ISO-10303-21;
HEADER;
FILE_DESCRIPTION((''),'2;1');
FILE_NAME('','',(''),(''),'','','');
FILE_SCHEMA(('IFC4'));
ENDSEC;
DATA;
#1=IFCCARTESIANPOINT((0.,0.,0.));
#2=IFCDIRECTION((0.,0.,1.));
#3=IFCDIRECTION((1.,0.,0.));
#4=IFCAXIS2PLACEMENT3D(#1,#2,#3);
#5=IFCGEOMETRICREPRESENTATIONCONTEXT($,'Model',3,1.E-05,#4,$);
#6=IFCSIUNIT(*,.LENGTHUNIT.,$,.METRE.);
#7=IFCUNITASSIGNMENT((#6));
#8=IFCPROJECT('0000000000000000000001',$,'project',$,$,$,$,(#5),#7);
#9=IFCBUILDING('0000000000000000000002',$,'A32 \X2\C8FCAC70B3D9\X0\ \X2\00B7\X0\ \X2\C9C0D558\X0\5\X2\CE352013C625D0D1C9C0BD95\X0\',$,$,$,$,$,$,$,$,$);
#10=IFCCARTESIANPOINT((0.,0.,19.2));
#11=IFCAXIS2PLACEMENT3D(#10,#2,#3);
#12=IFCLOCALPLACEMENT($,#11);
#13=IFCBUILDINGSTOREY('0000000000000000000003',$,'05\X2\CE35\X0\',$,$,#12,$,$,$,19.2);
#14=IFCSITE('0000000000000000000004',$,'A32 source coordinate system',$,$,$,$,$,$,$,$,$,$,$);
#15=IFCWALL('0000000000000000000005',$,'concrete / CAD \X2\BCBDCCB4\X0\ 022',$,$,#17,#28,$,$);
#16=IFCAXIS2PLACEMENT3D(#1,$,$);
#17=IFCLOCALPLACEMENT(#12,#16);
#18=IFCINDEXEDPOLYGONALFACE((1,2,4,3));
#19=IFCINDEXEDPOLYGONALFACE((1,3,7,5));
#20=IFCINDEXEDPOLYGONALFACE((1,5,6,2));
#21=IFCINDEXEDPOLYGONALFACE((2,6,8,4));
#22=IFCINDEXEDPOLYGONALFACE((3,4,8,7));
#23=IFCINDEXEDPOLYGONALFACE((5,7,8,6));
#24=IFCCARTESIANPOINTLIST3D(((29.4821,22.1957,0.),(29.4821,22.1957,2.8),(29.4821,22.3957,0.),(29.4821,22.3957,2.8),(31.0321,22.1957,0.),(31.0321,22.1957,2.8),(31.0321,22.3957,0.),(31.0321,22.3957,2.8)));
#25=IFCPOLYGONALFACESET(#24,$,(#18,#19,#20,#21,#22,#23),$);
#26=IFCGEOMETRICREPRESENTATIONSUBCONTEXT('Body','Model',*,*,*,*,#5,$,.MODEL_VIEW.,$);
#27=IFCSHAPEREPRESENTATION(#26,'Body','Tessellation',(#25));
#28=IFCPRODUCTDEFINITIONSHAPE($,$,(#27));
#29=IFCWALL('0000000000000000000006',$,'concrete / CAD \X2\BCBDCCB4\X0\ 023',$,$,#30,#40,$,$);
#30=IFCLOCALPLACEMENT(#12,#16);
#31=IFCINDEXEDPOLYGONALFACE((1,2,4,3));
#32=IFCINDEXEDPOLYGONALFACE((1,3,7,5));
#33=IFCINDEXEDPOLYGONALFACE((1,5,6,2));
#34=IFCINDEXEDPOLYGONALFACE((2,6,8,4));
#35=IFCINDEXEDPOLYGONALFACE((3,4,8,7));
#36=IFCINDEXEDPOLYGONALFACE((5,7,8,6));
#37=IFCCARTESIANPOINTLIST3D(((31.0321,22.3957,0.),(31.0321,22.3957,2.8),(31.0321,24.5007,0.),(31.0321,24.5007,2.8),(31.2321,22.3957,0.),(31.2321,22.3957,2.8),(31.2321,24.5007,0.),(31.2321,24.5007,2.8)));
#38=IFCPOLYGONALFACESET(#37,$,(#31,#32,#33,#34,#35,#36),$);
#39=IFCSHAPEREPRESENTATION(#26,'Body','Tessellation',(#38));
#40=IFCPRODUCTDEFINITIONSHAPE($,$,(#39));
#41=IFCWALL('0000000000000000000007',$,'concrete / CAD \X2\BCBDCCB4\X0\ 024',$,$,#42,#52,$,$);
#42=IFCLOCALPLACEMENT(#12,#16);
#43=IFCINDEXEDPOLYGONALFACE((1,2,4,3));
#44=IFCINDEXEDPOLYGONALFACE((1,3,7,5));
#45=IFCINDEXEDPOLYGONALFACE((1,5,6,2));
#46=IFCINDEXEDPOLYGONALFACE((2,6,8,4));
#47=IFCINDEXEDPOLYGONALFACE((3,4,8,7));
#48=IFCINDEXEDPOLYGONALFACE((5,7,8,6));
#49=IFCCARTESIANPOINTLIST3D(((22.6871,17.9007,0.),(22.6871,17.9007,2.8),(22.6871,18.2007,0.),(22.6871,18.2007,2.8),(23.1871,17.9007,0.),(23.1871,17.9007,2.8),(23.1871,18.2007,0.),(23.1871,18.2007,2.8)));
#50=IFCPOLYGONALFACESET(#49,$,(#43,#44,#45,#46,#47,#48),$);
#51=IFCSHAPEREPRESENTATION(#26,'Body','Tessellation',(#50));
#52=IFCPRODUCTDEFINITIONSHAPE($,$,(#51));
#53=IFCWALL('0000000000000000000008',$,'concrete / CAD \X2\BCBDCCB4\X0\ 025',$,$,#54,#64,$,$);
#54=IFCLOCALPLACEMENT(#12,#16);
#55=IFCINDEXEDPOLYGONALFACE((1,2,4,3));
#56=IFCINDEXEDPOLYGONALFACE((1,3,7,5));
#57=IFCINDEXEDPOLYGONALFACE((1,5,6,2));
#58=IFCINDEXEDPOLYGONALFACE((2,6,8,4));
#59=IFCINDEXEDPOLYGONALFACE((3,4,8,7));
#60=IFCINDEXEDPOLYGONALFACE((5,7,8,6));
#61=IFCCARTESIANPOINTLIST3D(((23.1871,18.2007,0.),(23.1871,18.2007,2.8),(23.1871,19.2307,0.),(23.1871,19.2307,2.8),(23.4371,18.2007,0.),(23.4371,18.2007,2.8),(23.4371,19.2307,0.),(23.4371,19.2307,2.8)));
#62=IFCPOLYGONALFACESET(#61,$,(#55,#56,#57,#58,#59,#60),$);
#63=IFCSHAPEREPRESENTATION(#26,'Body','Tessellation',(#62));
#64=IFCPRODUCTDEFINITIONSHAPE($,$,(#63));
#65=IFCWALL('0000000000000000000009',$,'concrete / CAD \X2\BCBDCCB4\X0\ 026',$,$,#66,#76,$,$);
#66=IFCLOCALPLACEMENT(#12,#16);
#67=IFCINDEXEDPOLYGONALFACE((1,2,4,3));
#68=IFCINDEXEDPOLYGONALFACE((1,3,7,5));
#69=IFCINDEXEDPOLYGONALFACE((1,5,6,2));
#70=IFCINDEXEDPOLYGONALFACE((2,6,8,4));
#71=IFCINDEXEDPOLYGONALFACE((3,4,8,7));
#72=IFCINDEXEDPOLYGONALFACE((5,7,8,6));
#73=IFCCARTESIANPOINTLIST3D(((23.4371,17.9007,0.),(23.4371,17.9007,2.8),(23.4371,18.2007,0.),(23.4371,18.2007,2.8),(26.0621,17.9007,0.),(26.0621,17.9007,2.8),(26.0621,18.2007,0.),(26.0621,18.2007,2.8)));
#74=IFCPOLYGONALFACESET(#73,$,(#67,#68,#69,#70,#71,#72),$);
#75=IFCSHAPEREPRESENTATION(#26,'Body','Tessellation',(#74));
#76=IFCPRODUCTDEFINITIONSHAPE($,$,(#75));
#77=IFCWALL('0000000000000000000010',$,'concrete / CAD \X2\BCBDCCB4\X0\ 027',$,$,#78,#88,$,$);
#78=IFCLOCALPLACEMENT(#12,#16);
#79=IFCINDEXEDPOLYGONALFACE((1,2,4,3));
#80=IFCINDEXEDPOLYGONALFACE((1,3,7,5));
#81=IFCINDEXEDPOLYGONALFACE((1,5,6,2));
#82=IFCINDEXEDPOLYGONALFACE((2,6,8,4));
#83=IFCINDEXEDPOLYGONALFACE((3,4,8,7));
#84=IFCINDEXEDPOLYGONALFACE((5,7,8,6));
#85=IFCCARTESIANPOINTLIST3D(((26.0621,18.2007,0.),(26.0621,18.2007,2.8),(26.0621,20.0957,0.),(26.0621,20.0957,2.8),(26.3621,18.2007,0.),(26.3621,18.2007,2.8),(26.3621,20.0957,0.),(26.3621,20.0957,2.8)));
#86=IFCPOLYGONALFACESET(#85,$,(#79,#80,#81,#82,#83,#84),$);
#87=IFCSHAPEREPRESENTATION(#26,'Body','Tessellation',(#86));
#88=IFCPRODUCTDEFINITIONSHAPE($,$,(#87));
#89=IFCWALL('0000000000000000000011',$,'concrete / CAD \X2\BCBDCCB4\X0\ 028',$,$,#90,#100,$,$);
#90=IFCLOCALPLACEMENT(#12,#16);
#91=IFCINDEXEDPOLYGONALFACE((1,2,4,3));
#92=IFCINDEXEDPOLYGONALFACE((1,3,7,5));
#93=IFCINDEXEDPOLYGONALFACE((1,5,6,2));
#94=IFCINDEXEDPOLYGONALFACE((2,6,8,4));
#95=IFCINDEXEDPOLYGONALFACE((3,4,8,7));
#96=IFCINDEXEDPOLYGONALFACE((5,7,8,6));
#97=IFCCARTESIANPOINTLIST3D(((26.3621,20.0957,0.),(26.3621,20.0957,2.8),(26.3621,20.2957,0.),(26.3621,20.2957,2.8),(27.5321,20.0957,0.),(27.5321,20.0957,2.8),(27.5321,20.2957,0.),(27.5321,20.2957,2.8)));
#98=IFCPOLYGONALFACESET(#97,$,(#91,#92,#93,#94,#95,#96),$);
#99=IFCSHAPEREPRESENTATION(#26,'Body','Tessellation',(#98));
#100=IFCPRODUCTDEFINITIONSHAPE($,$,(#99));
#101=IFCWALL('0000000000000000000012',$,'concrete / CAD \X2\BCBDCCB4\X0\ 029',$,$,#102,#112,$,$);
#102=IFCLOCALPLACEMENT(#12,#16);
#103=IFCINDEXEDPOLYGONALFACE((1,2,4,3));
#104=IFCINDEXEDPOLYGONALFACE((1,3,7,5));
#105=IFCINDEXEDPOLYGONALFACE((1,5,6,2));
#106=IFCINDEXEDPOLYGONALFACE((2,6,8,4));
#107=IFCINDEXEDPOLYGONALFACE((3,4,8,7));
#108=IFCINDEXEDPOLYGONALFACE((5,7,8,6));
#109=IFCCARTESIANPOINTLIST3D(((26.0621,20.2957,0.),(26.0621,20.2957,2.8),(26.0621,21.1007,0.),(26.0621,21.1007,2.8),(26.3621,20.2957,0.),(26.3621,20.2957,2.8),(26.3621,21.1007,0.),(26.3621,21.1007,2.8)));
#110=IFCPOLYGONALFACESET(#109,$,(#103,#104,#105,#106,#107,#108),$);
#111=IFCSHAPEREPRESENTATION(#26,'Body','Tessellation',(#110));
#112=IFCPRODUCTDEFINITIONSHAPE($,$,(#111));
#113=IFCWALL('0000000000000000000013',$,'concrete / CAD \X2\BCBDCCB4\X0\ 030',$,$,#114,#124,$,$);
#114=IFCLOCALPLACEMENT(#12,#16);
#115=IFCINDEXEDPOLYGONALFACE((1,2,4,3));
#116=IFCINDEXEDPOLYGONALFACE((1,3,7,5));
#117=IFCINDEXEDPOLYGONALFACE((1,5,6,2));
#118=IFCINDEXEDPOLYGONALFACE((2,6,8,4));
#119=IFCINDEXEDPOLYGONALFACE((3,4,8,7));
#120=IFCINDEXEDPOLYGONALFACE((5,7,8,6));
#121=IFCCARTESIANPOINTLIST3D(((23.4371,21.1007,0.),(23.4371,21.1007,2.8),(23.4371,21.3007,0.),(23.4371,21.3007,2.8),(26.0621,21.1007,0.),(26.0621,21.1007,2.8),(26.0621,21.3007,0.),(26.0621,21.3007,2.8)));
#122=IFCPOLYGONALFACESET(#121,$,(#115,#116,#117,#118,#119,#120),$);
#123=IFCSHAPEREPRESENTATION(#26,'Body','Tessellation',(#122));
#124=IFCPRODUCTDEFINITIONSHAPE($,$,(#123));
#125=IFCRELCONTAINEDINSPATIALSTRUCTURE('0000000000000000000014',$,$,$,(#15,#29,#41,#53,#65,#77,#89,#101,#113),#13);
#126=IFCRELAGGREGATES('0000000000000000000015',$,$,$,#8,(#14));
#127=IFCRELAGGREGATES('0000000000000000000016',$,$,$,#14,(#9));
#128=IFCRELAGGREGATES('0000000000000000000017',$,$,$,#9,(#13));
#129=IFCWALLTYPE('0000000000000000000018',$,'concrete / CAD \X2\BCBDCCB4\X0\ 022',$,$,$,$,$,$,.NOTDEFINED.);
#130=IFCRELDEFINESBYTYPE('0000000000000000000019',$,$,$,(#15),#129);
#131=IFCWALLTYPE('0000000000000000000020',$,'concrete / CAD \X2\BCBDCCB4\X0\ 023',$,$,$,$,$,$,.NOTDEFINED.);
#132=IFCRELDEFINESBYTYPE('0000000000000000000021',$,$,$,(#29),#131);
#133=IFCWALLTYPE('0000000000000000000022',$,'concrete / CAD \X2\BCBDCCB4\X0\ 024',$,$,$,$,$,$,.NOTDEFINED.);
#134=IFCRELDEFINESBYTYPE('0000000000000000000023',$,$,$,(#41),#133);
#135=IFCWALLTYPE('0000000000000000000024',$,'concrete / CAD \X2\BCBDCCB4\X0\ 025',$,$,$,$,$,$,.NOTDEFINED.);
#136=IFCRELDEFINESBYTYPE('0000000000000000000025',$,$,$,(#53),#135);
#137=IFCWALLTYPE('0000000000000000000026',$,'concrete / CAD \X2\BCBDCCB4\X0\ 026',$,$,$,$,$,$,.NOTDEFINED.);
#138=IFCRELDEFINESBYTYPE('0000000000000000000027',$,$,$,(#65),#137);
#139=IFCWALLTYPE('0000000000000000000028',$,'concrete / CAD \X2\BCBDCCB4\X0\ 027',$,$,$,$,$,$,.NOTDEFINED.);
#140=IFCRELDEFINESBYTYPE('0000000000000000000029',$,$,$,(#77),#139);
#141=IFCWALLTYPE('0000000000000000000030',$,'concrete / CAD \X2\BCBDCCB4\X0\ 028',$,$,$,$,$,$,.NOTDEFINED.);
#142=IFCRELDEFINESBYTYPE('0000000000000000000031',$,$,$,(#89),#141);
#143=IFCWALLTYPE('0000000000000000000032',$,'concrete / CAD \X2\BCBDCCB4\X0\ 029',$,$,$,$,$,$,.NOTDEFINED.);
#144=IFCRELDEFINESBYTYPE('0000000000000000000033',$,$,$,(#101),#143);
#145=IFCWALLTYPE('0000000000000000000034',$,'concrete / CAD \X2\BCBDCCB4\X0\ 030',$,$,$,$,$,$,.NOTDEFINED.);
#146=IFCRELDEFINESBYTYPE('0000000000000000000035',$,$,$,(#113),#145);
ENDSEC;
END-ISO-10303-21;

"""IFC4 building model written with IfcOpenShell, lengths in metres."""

from ifc_helpers import new_model, si_unit, frame, origin, origin_with_axes, place, context, subcontext, project, spatial, polyline, outline, extrude, source, transform, mapped, type_object, type_shapes, element, save


model = new_model("IFC4")

# Units and contexts
model_context = context("Model", 3, precision=1e-05, world=origin_with_axes())
body_context = subcontext(model_context, "Body", "Model", "MODEL_VIEW")
ifc_project = project(units=[si_unit("LENGTHUNIT", "METRE")], contexts=[model_context])

# Site, building, storey
site = spatial("IfcSite", under=ifc_project, Name="A32 source coordinate system")
building = spatial("IfcBuilding", under=site, Name="A32 주거동 · 지하5층–옥탑지붕")
storey_placement = place(None, frame((0.0, 0.0, 19.2), z_axis=(0.0, 0.0, 1.0), x_axis=(1.0, 0.0, 0.0)))
storey = spatial("IfcBuildingStorey", under=building, at=storey_placement, Name="05층", Elevation=19.2)

# Walls
wall_type_1 = type_object("IfcWallType", Name="concrete / CAD 벽체 022", PredefinedType="NOTDEFINED")
shared_shape_1 = source(origin(), body_context, "Body", "SweptSolid", [
    extrude(outline(polyline([(31.0321, 22.1957), (29.4821, 22.1957), (29.4821, 22.3957), (31.0321, 22.3957), (31.0321, 22.1957)])), origin(), (0.0, 0.0, 1.0), 2.8),
])
type_shapes(wall_type_1, [shared_shape_1])
wall_1_placement = place(storey_placement, origin_with_axes())
element("IfcWall", 1, at=wall_1_placement, inside=storey, type_object=wall_type_1, Name="concrete / CAD 벽체 022", context=body_context, shape_type="MappedRepresentation", body=[
    mapped(shared_shape_1, transform((0.0, 0.0, 0.0), scale=1.0)),
])
wall_type_2 = type_object("IfcWallType", Name="concrete / CAD 벽체 023", PredefinedType="NOTDEFINED")
shared_shape_2 = source(origin(), body_context, "Body", "SweptSolid", [
    extrude(outline(polyline([(31.2321, 24.5007), (31.2321, 22.3957), (31.0321, 22.3957), (31.0321, 24.5007), (31.2321, 24.5007)])), origin(), (0.0, 0.0, 1.0), 2.8),
])
type_shapes(wall_type_2, [shared_shape_2])
wall_2_placement = place(storey_placement, origin_with_axes())
element("IfcWall", 2, at=wall_2_placement, inside=storey, type_object=wall_type_2, Name="concrete / CAD 벽체 023", context=body_context, shape_type="MappedRepresentation", body=[
    mapped(shared_shape_2, transform((0.0, 0.0, 0.0), scale=1.0)),
])
wall_type_3 = type_object("IfcWallType", Name="concrete / CAD 벽체 024", PredefinedType="NOTDEFINED")
shared_shape_3 = source(origin(), body_context, "Body", "SweptSolid", [
    extrude(outline(polyline([(23.1871, 17.9007), (22.6871, 17.9007), (22.6871, 18.2007), (23.1871, 18.2007), (23.1871, 17.9007)])), origin(), (0.0, 0.0, 1.0), 2.8),
])
type_shapes(wall_type_3, [shared_shape_3])
wall_3_placement = place(storey_placement, origin_with_axes())
element("IfcWall", 3, at=wall_3_placement, inside=storey, type_object=wall_type_3, Name="concrete / CAD 벽체 024", context=body_context, shape_type="MappedRepresentation", body=[
    mapped(shared_shape_3, transform((0.0, 0.0, 0.0), scale=1.0)),
])
wall_type_4 = type_object("IfcWallType", Name="concrete / CAD 벽체 025", PredefinedType="NOTDEFINED")
shared_shape_4 = source(origin(), body_context, "Body", "SweptSolid", [
    extrude(outline(polyline([(23.4371, 19.2307), (23.4371, 18.2007), (23.1871, 18.2007), (23.1871, 19.2307), (23.4371, 19.2307)])), origin(), (0.0, 0.0, 1.0), 2.8),
])
type_shapes(wall_type_4, [shared_shape_4])
wall_4_placement = place(storey_placement, origin_with_axes())
element("IfcWall", 4, at=wall_4_placement, inside=storey, type_object=wall_type_4, Name="concrete / CAD 벽체 025", context=body_context, shape_type="MappedRepresentation", body=[
    mapped(shared_shape_4, transform((0.0, 0.0, 0.0), scale=1.0)),
])
wall_type_5 = type_object("IfcWallType", Name="concrete / CAD 벽체 026", PredefinedType="NOTDEFINED")
shared_shape_5 = source(origin(), body_context, "Body", "SweptSolid", [
    extrude(outline(polyline([(26.0621, 17.9007), (23.4371, 17.9007), (23.4371, 18.2007), (26.0621, 18.2007), (26.0621, 17.9007)])), origin(), (0.0, 0.0, 1.0), 2.8),
])
type_shapes(wall_type_5, [shared_shape_5])
wall_5_placement = place(storey_placement, origin_with_axes())
element("IfcWall", 5, at=wall_5_placement, inside=storey, type_object=wall_type_5, Name="concrete / CAD 벽체 026", context=body_context, shape_type="MappedRepresentation", body=[
    mapped(shared_shape_5, transform((0.0, 0.0, 0.0), scale=1.0)),
])
wall_type_6 = type_object("IfcWallType", Name="concrete / CAD 벽체 027", PredefinedType="NOTDEFINED")
shared_shape_6 = source(origin(), body_context, "Body", "SweptSolid", [
    extrude(outline(polyline([(26.3621, 20.0957), (26.3621, 18.2007), (26.0621, 18.2007), (26.0621, 20.0957), (26.3621, 20.0957)])), origin(), (0.0, 0.0, 1.0), 2.8),
])
type_shapes(wall_type_6, [shared_shape_6])
wall_6_placement = place(storey_placement, origin_with_axes())
element("IfcWall", 6, at=wall_6_placement, inside=storey, type_object=wall_type_6, Name="concrete / CAD 벽체 027", context=body_context, shape_type="MappedRepresentation", body=[
    mapped(shared_shape_6, transform((0.0, 0.0, 0.0), scale=1.0)),
])
wall_type_7 = type_object("IfcWallType", Name="concrete / CAD 벽체 028", PredefinedType="NOTDEFINED")
shared_shape_7 = source(origin(), body_context, "Body", "SweptSolid", [
    extrude(outline(polyline([(27.5321, 20.0957), (26.3621, 20.0957), (26.3621, 20.2957), (27.5321, 20.2957), (27.5321, 20.0957)])), origin(), (0.0, 0.0, 1.0), 2.8),
])
type_shapes(wall_type_7, [shared_shape_7])
wall_7_placement = place(storey_placement, origin_with_axes())
element("IfcWall", 7, at=wall_7_placement, inside=storey, type_object=wall_type_7, Name="concrete / CAD 벽체 028", context=body_context, shape_type="MappedRepresentation", body=[
    mapped(shared_shape_7, transform((0.0, 0.0, 0.0), scale=1.0)),
])
wall_type_8 = type_object("IfcWallType", Name="concrete / CAD 벽체 029", PredefinedType="NOTDEFINED")
shared_shape_8 = source(origin(), body_context, "Body", "SweptSolid", [
    extrude(outline(polyline([(26.3621, 21.1007), (26.3621, 20.2957), (26.0621, 20.2957), (26.0621, 21.1007), (26.3621, 21.1007)])), origin(), (0.0, 0.0, 1.0), 2.8),
])
type_shapes(wall_type_8, [shared_shape_8])
wall_8_placement = place(storey_placement, origin_with_axes())
element("IfcWall", 8, at=wall_8_placement, inside=storey, type_object=wall_type_8, Name="concrete / CAD 벽체 029", context=body_context, shape_type="MappedRepresentation", body=[
    mapped(shared_shape_8, transform((0.0, 0.0, 0.0), scale=1.0)),
])
wall_type_9 = type_object("IfcWallType", Name="concrete / CAD 벽체 030", PredefinedType="NOTDEFINED")
shared_shape_9 = source(origin(), body_context, "Body", "SweptSolid", [
    extrude(outline(polyline([(23.4371, 21.3007), (26.0621, 21.3007), (26.0621, 21.1007), (23.4371, 21.1007), (23.4371, 21.3007)])), origin(), (0.0, 0.0, 1.0), 2.8),
])
type_shapes(wall_type_9, [shared_shape_9])
wall_9_placement = place(storey_placement, origin_with_axes())
element("IfcWall", 9, at=wall_9_placement, inside=storey, type_object=wall_type_9, Name="concrete / CAD 벽체 030", context=body_context, shape_type="MappedRepresentation", body=[
    mapped(shared_shape_9, transform((0.0, 0.0, 0.0), scale=1.0)),
])

save(model, "model.ifc")
